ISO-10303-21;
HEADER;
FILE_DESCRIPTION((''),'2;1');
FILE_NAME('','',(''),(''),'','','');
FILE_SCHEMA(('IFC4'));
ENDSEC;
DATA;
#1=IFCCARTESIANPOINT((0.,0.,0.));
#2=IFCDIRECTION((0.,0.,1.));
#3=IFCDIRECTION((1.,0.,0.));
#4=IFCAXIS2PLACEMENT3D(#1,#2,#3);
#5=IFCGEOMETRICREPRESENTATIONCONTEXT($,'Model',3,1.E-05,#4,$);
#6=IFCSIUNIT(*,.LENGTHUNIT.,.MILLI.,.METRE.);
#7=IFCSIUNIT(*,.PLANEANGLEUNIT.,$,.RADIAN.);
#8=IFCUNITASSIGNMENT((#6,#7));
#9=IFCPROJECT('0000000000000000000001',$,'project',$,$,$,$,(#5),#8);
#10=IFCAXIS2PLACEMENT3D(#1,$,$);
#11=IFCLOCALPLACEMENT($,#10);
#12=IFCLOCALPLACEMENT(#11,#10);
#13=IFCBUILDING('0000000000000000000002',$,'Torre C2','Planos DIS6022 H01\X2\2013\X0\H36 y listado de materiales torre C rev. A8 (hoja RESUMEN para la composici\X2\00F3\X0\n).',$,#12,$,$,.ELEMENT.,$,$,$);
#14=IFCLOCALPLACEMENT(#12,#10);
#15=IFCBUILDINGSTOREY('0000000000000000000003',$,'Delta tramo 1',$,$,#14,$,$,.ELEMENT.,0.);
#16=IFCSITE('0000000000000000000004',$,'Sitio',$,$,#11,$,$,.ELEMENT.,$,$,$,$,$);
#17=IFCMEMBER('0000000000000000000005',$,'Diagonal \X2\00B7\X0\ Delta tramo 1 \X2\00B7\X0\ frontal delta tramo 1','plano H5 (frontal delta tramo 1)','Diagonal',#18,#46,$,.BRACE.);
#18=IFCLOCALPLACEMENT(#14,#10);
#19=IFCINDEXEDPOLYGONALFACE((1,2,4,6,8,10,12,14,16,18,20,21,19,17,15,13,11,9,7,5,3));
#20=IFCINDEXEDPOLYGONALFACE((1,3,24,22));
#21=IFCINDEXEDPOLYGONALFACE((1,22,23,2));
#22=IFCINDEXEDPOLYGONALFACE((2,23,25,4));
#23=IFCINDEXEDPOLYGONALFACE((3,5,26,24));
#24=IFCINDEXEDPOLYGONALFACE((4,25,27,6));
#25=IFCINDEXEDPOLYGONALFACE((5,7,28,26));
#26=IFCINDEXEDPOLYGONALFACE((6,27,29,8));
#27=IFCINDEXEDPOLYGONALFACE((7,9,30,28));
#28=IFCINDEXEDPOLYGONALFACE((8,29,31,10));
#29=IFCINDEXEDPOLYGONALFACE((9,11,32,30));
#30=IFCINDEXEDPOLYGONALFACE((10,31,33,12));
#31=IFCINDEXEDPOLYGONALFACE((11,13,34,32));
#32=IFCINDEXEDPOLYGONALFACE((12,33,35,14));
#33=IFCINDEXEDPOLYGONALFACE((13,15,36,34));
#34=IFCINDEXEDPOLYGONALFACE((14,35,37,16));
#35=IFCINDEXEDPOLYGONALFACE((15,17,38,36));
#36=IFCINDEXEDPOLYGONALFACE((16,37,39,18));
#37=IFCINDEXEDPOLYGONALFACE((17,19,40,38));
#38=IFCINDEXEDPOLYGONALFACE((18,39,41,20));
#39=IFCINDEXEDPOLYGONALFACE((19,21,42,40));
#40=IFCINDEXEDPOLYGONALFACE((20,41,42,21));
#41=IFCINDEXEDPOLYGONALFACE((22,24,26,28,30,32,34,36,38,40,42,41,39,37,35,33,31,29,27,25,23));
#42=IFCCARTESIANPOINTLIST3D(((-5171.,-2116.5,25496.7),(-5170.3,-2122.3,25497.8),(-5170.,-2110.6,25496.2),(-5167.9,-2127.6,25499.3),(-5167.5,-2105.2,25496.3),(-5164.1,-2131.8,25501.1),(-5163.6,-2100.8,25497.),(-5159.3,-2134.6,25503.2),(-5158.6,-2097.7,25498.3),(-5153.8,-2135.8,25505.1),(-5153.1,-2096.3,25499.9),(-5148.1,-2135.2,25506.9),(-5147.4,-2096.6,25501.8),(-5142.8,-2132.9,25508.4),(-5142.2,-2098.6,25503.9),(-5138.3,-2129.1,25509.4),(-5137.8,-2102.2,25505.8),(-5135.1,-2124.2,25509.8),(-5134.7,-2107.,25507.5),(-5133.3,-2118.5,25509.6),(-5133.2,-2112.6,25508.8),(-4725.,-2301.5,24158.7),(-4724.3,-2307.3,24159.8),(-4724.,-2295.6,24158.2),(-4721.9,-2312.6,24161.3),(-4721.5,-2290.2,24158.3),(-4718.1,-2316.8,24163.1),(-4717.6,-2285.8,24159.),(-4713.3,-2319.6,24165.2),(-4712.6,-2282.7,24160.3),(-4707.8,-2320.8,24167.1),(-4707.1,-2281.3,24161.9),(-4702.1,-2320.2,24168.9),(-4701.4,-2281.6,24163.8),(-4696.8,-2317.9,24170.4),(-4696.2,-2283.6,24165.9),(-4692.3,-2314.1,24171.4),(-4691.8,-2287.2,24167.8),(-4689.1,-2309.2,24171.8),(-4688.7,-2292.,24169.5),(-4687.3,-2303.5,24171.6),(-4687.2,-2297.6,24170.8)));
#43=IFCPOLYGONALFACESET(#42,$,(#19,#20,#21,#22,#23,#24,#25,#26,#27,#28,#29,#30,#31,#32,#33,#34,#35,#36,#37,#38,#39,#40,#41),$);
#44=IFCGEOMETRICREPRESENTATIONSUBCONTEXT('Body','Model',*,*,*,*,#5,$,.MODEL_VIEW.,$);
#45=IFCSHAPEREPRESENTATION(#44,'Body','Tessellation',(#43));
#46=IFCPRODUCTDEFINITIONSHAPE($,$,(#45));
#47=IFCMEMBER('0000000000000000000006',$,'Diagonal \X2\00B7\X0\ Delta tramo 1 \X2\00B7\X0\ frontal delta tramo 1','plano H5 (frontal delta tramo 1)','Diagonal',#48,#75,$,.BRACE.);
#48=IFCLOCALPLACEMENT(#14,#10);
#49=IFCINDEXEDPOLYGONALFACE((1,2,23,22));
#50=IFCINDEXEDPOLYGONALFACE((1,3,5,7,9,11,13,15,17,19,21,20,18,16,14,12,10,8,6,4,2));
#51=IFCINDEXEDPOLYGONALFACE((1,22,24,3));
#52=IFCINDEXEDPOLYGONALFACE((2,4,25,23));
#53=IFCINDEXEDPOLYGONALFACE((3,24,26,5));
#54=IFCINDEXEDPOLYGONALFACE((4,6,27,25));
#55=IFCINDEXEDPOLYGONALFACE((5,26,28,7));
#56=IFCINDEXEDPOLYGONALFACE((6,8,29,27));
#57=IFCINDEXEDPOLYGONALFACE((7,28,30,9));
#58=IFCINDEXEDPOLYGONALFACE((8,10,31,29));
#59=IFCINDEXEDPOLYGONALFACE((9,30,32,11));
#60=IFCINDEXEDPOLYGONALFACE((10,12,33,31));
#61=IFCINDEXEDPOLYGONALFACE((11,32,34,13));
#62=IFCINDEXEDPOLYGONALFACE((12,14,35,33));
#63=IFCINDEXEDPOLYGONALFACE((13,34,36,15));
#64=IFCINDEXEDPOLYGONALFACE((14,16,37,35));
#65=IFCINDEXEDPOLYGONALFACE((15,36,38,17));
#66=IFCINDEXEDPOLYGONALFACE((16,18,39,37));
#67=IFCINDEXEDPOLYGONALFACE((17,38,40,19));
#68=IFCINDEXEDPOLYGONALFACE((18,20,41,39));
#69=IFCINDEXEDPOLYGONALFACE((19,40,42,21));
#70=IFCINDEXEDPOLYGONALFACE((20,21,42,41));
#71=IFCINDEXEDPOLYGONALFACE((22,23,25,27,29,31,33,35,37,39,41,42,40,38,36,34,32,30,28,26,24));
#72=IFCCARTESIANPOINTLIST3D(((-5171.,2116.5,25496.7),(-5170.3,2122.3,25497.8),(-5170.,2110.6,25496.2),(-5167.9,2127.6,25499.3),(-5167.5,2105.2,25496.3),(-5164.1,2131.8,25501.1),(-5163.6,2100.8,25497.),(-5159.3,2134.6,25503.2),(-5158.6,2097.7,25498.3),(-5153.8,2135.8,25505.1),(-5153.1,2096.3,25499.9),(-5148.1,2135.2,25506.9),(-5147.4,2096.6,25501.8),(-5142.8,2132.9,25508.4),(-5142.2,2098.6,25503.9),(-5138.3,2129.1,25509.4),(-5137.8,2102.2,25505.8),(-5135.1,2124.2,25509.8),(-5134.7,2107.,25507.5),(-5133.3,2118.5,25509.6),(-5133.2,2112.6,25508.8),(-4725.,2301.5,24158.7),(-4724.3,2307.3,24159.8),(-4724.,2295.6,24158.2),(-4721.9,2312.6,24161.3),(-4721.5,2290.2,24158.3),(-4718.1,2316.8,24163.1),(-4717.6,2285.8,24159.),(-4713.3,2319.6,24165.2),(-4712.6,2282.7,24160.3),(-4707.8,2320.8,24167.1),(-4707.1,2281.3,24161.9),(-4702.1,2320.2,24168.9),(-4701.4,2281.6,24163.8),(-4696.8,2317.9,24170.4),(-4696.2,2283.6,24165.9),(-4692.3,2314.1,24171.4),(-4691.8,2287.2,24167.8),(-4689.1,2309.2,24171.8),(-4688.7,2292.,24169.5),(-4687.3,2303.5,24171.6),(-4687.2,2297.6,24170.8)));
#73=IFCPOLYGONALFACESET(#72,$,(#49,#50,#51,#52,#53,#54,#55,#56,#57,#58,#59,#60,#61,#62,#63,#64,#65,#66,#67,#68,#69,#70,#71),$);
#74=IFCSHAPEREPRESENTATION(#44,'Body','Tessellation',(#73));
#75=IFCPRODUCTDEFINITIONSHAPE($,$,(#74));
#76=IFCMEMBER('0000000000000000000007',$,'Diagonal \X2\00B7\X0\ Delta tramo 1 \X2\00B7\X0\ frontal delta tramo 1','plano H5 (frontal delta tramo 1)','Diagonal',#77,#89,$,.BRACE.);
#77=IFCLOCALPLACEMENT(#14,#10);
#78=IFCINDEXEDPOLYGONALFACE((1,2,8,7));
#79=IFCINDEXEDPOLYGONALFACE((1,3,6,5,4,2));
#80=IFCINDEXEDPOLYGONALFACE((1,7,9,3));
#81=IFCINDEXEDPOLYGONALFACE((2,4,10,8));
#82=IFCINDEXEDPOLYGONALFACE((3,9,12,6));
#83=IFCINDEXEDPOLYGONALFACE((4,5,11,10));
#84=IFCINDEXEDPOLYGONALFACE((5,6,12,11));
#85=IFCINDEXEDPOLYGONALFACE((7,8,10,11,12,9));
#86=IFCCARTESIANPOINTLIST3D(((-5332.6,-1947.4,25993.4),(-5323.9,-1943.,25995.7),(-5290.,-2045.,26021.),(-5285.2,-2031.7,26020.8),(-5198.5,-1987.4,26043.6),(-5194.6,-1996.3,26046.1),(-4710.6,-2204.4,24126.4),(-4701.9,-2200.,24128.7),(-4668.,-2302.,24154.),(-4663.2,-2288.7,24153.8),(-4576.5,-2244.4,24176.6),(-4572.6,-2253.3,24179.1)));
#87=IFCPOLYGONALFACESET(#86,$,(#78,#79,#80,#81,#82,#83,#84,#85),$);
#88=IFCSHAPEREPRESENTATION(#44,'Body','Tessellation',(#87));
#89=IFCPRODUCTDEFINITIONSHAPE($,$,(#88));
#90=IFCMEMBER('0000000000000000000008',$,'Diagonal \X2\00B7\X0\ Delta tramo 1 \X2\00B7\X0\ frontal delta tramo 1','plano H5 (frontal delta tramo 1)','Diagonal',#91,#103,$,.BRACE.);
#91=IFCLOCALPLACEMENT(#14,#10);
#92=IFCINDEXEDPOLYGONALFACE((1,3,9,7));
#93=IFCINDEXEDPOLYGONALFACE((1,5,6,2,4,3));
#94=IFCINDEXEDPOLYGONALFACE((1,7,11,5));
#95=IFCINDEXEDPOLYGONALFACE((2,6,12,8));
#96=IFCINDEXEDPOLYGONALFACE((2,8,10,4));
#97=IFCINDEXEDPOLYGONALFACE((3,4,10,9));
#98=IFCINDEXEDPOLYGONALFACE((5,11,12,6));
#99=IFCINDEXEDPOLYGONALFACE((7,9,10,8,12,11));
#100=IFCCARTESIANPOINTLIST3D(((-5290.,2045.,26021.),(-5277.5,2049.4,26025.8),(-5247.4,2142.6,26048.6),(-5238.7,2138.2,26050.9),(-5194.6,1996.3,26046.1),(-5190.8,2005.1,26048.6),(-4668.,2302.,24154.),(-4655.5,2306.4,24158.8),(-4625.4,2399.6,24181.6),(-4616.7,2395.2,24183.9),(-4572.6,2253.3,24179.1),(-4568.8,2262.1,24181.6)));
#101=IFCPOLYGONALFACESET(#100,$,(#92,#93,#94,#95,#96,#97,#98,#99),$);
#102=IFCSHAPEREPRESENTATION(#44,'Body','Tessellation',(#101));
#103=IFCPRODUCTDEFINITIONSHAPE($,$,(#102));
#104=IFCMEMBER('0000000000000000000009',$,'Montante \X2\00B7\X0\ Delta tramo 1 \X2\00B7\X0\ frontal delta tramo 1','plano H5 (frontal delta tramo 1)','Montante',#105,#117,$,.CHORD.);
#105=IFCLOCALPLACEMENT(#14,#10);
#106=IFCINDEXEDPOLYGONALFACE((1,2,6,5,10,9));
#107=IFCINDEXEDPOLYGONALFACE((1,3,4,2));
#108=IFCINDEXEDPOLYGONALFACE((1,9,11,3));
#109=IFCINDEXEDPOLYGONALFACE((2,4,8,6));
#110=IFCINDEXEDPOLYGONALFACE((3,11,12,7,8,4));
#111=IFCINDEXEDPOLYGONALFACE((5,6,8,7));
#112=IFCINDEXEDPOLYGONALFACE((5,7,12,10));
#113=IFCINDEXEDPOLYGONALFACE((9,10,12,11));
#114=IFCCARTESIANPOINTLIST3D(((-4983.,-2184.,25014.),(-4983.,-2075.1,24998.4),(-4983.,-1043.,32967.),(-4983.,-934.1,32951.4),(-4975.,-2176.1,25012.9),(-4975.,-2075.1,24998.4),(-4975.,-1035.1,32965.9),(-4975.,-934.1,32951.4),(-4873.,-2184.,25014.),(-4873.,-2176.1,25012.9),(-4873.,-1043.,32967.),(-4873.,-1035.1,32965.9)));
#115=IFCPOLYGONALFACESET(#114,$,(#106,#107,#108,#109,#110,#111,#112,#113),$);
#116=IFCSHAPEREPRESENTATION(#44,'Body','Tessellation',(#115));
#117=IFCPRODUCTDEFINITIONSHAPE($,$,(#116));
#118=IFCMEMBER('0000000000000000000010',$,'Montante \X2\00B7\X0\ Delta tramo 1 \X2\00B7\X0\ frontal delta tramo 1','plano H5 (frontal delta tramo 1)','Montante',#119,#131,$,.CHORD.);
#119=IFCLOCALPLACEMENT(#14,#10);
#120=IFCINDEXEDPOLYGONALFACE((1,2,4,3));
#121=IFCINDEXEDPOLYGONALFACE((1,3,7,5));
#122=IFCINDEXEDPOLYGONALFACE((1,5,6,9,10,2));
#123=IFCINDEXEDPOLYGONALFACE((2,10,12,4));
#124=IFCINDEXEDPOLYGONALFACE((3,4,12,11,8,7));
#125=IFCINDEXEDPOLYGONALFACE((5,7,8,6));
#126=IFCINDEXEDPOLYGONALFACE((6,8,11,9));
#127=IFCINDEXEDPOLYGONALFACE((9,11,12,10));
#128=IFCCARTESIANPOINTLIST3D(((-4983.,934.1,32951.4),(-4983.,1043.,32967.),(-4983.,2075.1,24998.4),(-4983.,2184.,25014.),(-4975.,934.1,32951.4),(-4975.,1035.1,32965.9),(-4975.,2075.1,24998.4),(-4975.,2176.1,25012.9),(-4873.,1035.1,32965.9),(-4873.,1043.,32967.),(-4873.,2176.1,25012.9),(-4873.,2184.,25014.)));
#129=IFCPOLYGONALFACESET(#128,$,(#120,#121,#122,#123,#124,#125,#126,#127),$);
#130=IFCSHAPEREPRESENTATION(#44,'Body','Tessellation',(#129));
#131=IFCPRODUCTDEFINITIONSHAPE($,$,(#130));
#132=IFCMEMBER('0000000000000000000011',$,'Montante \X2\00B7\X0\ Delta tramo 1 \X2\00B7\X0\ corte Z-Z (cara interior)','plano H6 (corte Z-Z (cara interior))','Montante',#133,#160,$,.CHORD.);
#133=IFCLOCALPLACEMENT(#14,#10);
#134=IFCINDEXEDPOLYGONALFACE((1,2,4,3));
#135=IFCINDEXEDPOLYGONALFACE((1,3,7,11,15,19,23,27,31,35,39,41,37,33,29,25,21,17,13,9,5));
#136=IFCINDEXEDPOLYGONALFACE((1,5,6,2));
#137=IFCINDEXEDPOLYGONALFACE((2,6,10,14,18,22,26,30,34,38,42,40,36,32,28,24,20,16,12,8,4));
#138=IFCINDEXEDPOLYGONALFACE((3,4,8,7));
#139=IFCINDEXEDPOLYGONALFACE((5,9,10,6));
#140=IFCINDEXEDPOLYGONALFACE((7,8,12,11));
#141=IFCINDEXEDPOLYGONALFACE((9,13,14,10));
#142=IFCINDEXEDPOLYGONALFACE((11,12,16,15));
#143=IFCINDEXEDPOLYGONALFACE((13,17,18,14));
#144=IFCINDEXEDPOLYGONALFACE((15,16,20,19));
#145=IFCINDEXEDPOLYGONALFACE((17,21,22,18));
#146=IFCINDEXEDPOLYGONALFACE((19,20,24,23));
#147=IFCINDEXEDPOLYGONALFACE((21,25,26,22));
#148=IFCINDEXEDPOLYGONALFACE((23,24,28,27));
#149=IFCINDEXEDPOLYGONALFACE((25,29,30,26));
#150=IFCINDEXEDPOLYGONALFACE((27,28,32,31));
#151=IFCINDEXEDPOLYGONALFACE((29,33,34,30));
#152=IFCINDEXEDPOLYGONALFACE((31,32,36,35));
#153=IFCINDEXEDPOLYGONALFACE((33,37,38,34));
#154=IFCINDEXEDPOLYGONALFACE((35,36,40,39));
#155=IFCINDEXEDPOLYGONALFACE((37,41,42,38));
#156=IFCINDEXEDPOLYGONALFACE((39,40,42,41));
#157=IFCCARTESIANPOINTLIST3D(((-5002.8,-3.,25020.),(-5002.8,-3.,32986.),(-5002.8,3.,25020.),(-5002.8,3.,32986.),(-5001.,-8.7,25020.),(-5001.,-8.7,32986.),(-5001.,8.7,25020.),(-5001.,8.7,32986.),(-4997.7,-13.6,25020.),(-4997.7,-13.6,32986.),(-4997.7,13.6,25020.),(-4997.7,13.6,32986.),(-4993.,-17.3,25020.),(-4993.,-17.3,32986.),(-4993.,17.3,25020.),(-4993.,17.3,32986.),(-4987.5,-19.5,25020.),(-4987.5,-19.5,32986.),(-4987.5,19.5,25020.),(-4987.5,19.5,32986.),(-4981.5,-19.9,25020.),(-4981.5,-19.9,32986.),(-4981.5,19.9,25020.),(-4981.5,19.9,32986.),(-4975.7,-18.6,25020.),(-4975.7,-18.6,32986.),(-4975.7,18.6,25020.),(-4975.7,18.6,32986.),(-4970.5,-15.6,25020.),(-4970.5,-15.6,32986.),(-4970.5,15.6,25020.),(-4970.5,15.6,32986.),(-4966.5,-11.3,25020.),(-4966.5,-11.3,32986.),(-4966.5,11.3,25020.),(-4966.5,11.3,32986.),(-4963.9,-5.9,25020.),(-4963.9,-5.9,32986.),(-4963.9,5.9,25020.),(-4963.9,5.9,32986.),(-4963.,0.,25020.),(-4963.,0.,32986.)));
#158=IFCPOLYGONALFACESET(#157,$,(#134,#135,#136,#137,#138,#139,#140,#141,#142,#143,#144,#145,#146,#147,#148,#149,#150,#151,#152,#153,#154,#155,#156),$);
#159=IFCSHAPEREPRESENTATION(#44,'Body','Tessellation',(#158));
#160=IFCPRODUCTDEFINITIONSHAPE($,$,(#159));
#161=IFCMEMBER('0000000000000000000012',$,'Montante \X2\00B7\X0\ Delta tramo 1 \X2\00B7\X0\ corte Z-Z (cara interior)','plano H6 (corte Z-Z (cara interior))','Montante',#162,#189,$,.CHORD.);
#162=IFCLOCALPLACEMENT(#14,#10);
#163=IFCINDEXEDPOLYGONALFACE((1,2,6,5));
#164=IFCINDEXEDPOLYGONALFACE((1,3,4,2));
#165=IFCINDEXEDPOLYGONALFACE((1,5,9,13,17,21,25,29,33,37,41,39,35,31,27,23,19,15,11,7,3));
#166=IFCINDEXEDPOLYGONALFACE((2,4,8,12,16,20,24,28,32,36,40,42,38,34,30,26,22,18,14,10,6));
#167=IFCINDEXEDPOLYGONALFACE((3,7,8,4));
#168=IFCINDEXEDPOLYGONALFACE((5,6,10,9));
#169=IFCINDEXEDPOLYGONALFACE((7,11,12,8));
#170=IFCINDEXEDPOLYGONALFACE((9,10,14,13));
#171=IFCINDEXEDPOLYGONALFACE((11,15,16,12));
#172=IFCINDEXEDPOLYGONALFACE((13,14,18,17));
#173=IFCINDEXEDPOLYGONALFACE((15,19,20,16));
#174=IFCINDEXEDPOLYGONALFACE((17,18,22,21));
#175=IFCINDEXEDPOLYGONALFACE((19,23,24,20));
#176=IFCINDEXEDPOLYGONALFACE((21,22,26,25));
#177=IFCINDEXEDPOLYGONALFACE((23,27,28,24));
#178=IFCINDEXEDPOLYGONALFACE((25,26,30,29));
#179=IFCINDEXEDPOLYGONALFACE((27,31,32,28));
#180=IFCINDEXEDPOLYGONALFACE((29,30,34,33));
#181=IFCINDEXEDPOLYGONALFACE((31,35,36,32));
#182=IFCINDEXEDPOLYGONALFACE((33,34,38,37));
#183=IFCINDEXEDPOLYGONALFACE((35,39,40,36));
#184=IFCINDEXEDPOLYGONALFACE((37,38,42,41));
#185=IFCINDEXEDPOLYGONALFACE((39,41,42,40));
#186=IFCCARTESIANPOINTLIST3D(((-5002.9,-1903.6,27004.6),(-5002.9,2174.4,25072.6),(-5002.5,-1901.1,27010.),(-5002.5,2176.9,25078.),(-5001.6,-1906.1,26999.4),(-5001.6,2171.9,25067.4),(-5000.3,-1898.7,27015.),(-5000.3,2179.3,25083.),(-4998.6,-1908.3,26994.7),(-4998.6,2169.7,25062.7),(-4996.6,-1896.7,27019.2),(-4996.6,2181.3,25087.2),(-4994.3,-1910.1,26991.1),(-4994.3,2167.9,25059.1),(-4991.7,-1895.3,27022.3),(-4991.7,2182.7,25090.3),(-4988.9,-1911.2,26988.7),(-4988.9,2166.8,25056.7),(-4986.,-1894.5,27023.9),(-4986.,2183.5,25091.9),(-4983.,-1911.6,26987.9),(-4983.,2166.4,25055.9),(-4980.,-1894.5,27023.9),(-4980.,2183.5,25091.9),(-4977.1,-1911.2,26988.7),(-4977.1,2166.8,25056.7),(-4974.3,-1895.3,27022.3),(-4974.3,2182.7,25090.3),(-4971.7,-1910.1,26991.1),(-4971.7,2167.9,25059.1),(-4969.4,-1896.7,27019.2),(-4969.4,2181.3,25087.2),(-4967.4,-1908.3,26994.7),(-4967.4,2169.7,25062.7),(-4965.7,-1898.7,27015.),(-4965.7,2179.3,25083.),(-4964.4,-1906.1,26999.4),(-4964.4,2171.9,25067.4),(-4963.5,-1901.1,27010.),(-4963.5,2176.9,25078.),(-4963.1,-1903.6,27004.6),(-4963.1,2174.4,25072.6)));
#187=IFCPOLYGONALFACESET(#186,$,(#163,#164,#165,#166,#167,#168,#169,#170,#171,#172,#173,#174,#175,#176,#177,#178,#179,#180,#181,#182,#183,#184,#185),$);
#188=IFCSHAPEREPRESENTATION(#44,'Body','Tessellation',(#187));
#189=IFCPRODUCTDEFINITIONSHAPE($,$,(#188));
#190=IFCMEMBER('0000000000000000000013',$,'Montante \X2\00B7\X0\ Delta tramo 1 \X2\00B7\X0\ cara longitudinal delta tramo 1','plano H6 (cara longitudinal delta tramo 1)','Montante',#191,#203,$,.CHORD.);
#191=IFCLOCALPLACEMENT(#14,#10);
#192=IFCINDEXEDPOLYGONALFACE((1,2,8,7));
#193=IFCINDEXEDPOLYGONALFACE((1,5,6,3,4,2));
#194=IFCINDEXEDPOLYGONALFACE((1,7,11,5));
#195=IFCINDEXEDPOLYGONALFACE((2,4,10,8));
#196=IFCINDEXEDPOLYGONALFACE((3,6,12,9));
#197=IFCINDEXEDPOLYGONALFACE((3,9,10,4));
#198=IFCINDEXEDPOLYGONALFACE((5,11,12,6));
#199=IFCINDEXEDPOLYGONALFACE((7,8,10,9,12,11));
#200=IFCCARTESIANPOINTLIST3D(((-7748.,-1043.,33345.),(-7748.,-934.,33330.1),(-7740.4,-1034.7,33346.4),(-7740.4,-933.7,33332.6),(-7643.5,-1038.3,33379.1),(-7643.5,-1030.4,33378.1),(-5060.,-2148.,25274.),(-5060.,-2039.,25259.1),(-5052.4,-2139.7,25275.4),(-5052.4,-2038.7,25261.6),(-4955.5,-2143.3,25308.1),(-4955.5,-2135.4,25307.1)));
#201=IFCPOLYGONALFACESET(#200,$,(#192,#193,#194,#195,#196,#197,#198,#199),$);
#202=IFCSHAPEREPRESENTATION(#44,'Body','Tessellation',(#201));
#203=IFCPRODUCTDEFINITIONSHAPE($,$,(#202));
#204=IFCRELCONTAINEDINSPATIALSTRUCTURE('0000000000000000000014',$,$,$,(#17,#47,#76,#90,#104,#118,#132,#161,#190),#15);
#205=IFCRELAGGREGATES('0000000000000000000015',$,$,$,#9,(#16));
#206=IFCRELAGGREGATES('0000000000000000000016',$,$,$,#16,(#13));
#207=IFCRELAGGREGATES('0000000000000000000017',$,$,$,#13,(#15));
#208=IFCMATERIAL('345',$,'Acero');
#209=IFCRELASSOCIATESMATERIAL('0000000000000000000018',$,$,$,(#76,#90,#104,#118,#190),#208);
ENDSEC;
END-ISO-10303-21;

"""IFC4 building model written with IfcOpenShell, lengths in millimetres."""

from ifc_helpers import new_model, si_unit, frame, frame_2d, origin, origin_with_axes, place, context, subcontext, project, spatial, circle, l_section, extrude, material, element, save


model = new_model("IFC4")

# Units and contexts
model_context = context("Model", 3, precision=1e-05, world=origin_with_axes())
body_context = subcontext(model_context, "Body", "Model", "MODEL_VIEW")
ifc_project = project(units=[si_unit("LENGTHUNIT", "METRE", prefix="MILLI"), si_unit("PLANEANGLEUNIT", "RADIAN")], contexts=[model_context])

# Site, building, storey
site_placement = place(None, origin())
site = spatial("IfcSite", under=ifc_project, at=site_placement, Name="Sitio", CompositionType="ELEMENT")
building_placement = place(site_placement, origin())
building = spatial("IfcBuilding", under=site, at=building_placement, Name="Torre C2", Description="Planos DIS6022 H01–H36 y listado de materiales torre C rev. A8 (hoja RESUMEN para la composición).", CompositionType="ELEMENT")
storey_placement = place(building_placement, origin())
storey = spatial("IfcBuildingStorey", under=building, at=storey_placement, Name="Delta tramo 1", CompositionType="ELEMENT", Elevation=0.0)

# Members
for number, where, z_axis, x_axis, name in (
    (1, (-4706.0, -2301.0, 24165.0), (-0.313542, 0.130057, 0.940626), (0.863292, 0.451616, 0.225321), "Diagonal · Delta tramo 1 · frontal delta tramo 1"),
    (2, (-4706.0, 2301.0, 24165.0), (-0.313542, -0.130057, 0.940626), (0.863292, -0.451616, 0.225321), "Diagonal · Delta tramo 1 · frontal delta tramo 1"),
):
    element("IfcMember", number, at=place(storey_placement, frame(where, z_axis=z_axis, x_axis=x_axis)), inside=storey, Name=name, Description="plano H5 (frontal delta tramo 1)", ObjectType="Diagonal", PredefinedType="BRACE", context=body_context, shape_type="SweptSolid", body=[
        extrude(circle(Radius=20.0), None, (0.0, 0.0, 1.0), 1422.5),
    ])
ifc_material_1 = material(Name="345", Category="Acero")
for number, where, z_axis, x_axis, name in (
    (3, (-4668.0, -2302.0, 24154.0), (-0.313414, 0.129497, 0.940746), (0.867067, 0.443015, 0.227885), "Diagonal · Delta tramo 1 · frontal delta tramo 1"),
    (4, (-4668.0, 2302.0, 24154.0), (-0.313414, -0.129497, 0.940746), (0.867067, -0.443015, 0.227885), "Diagonal · Delta tramo 1 · frontal delta tramo 1"),
):
    element("IfcMember", number, at=place(storey_placement, frame(where, z_axis=z_axis, x_axis=x_axis)), inside=storey, material=ifc_material_1, Name=name, Description="plano H5 (frontal delta tramo 1)", ObjectType="Diagonal", PredefinedType="BRACE", context=body_context, shape_type="SweptSolid", body=[
        extrude(l_section(Depth=110.0, Width=110.0, Thickness=10.0, at=frame_2d((55.0, 55.0))), None, (0.0, 0.0, 1.0), 1984.6),
    ])
for number, where, z_axis, x_axis, name in (
    (5, (-4983.0, -2184.0, 25014.0), (0.0, 0.142014, 0.989865), (1.0, 0.0, 0.0), "Montante · Delta tramo 1 · frontal delta tramo 1"),
    (6, (-4983.0, 2184.0, 25014.0), (0.0, -0.142014, 0.989865), (0.0, -0.989865, -0.142014), "Montante · Delta tramo 1 · frontal delta tramo 1"),
):
    element("IfcMember", number, at=place(storey_placement, frame(where, z_axis=z_axis, x_axis=x_axis)), inside=storey, material=ifc_material_1, Name=name, Description="plano H5 (frontal delta tramo 1)", ObjectType="Montante", PredefinedType="CHORD", context=body_context, shape_type="SweptSolid", body=[
        extrude(l_section(Depth=110.0, Width=110.0, Thickness=8.0, at=frame_2d((55.0, 55.0))), None, (0.0, 0.0, 1.0), 8034.4),
    ])
member_1_placement = place(storey_placement, frame((-4983.0, 0.0, 25020.0), z_axis=(0.0, 0.0, 1.0), x_axis=(1.0, 0.0, 0.0)))
element("IfcMember", 7, at=member_1_placement, inside=storey, Name="Montante · Delta tramo 1 · corte Z-Z (cara interior)", Description="plano H6 (corte Z-Z (cara interior))", ObjectType="Montante", PredefinedType="CHORD", context=body_context, shape_type="SweptSolid", body=[
    extrude(circle(Radius=20.0), None, (0.0, 0.0, 1.0), 7966.0),
])
member_2_placement = place(storey_placement, frame((-4983.0, 2175.0, 25074.0), z_axis=(0.0, -0.903711, 0.428144), x_axis=(0.0, -0.428144, -0.903711)))
element("IfcMember", 8, at=member_2_placement, inside=storey, Name="Montante · Delta tramo 1 · corte Z-Z (cara interior)", Description="plano H6 (corte Z-Z (cara interior))", ObjectType="Montante", PredefinedType="CHORD", context=body_context, shape_type="SweptSolid", body=[
    extrude(circle(Radius=20.0), None, (0.0, 0.0, 1.0), 4512.5),
])
member_3_placement = place(storey_placement, frame((-5060.0, -2148.0, 25274.0), z_axis=(-0.313348, 0.128813, 0.940861), x_axis=(0.949638, 0.042504, 0.310452)))
element("IfcMember", 9, at=member_3_placement, inside=storey, material=ifc_material_1, Name="Montante · Delta tramo 1 · cara longitudinal delta tramo 1", Description="plano H6 (cara longitudinal delta tramo 1)", ObjectType="Montante", PredefinedType="CHORD", context=body_context, shape_type="SweptSolid", body=[
    extrude(l_section(Depth=110.0, Width=110.0, Thickness=8.0, at=frame_2d((55.0, 55.0))), None, (0.0, 0.0, 1.0), 8578.3),
])

save(model, "model.ifc")
